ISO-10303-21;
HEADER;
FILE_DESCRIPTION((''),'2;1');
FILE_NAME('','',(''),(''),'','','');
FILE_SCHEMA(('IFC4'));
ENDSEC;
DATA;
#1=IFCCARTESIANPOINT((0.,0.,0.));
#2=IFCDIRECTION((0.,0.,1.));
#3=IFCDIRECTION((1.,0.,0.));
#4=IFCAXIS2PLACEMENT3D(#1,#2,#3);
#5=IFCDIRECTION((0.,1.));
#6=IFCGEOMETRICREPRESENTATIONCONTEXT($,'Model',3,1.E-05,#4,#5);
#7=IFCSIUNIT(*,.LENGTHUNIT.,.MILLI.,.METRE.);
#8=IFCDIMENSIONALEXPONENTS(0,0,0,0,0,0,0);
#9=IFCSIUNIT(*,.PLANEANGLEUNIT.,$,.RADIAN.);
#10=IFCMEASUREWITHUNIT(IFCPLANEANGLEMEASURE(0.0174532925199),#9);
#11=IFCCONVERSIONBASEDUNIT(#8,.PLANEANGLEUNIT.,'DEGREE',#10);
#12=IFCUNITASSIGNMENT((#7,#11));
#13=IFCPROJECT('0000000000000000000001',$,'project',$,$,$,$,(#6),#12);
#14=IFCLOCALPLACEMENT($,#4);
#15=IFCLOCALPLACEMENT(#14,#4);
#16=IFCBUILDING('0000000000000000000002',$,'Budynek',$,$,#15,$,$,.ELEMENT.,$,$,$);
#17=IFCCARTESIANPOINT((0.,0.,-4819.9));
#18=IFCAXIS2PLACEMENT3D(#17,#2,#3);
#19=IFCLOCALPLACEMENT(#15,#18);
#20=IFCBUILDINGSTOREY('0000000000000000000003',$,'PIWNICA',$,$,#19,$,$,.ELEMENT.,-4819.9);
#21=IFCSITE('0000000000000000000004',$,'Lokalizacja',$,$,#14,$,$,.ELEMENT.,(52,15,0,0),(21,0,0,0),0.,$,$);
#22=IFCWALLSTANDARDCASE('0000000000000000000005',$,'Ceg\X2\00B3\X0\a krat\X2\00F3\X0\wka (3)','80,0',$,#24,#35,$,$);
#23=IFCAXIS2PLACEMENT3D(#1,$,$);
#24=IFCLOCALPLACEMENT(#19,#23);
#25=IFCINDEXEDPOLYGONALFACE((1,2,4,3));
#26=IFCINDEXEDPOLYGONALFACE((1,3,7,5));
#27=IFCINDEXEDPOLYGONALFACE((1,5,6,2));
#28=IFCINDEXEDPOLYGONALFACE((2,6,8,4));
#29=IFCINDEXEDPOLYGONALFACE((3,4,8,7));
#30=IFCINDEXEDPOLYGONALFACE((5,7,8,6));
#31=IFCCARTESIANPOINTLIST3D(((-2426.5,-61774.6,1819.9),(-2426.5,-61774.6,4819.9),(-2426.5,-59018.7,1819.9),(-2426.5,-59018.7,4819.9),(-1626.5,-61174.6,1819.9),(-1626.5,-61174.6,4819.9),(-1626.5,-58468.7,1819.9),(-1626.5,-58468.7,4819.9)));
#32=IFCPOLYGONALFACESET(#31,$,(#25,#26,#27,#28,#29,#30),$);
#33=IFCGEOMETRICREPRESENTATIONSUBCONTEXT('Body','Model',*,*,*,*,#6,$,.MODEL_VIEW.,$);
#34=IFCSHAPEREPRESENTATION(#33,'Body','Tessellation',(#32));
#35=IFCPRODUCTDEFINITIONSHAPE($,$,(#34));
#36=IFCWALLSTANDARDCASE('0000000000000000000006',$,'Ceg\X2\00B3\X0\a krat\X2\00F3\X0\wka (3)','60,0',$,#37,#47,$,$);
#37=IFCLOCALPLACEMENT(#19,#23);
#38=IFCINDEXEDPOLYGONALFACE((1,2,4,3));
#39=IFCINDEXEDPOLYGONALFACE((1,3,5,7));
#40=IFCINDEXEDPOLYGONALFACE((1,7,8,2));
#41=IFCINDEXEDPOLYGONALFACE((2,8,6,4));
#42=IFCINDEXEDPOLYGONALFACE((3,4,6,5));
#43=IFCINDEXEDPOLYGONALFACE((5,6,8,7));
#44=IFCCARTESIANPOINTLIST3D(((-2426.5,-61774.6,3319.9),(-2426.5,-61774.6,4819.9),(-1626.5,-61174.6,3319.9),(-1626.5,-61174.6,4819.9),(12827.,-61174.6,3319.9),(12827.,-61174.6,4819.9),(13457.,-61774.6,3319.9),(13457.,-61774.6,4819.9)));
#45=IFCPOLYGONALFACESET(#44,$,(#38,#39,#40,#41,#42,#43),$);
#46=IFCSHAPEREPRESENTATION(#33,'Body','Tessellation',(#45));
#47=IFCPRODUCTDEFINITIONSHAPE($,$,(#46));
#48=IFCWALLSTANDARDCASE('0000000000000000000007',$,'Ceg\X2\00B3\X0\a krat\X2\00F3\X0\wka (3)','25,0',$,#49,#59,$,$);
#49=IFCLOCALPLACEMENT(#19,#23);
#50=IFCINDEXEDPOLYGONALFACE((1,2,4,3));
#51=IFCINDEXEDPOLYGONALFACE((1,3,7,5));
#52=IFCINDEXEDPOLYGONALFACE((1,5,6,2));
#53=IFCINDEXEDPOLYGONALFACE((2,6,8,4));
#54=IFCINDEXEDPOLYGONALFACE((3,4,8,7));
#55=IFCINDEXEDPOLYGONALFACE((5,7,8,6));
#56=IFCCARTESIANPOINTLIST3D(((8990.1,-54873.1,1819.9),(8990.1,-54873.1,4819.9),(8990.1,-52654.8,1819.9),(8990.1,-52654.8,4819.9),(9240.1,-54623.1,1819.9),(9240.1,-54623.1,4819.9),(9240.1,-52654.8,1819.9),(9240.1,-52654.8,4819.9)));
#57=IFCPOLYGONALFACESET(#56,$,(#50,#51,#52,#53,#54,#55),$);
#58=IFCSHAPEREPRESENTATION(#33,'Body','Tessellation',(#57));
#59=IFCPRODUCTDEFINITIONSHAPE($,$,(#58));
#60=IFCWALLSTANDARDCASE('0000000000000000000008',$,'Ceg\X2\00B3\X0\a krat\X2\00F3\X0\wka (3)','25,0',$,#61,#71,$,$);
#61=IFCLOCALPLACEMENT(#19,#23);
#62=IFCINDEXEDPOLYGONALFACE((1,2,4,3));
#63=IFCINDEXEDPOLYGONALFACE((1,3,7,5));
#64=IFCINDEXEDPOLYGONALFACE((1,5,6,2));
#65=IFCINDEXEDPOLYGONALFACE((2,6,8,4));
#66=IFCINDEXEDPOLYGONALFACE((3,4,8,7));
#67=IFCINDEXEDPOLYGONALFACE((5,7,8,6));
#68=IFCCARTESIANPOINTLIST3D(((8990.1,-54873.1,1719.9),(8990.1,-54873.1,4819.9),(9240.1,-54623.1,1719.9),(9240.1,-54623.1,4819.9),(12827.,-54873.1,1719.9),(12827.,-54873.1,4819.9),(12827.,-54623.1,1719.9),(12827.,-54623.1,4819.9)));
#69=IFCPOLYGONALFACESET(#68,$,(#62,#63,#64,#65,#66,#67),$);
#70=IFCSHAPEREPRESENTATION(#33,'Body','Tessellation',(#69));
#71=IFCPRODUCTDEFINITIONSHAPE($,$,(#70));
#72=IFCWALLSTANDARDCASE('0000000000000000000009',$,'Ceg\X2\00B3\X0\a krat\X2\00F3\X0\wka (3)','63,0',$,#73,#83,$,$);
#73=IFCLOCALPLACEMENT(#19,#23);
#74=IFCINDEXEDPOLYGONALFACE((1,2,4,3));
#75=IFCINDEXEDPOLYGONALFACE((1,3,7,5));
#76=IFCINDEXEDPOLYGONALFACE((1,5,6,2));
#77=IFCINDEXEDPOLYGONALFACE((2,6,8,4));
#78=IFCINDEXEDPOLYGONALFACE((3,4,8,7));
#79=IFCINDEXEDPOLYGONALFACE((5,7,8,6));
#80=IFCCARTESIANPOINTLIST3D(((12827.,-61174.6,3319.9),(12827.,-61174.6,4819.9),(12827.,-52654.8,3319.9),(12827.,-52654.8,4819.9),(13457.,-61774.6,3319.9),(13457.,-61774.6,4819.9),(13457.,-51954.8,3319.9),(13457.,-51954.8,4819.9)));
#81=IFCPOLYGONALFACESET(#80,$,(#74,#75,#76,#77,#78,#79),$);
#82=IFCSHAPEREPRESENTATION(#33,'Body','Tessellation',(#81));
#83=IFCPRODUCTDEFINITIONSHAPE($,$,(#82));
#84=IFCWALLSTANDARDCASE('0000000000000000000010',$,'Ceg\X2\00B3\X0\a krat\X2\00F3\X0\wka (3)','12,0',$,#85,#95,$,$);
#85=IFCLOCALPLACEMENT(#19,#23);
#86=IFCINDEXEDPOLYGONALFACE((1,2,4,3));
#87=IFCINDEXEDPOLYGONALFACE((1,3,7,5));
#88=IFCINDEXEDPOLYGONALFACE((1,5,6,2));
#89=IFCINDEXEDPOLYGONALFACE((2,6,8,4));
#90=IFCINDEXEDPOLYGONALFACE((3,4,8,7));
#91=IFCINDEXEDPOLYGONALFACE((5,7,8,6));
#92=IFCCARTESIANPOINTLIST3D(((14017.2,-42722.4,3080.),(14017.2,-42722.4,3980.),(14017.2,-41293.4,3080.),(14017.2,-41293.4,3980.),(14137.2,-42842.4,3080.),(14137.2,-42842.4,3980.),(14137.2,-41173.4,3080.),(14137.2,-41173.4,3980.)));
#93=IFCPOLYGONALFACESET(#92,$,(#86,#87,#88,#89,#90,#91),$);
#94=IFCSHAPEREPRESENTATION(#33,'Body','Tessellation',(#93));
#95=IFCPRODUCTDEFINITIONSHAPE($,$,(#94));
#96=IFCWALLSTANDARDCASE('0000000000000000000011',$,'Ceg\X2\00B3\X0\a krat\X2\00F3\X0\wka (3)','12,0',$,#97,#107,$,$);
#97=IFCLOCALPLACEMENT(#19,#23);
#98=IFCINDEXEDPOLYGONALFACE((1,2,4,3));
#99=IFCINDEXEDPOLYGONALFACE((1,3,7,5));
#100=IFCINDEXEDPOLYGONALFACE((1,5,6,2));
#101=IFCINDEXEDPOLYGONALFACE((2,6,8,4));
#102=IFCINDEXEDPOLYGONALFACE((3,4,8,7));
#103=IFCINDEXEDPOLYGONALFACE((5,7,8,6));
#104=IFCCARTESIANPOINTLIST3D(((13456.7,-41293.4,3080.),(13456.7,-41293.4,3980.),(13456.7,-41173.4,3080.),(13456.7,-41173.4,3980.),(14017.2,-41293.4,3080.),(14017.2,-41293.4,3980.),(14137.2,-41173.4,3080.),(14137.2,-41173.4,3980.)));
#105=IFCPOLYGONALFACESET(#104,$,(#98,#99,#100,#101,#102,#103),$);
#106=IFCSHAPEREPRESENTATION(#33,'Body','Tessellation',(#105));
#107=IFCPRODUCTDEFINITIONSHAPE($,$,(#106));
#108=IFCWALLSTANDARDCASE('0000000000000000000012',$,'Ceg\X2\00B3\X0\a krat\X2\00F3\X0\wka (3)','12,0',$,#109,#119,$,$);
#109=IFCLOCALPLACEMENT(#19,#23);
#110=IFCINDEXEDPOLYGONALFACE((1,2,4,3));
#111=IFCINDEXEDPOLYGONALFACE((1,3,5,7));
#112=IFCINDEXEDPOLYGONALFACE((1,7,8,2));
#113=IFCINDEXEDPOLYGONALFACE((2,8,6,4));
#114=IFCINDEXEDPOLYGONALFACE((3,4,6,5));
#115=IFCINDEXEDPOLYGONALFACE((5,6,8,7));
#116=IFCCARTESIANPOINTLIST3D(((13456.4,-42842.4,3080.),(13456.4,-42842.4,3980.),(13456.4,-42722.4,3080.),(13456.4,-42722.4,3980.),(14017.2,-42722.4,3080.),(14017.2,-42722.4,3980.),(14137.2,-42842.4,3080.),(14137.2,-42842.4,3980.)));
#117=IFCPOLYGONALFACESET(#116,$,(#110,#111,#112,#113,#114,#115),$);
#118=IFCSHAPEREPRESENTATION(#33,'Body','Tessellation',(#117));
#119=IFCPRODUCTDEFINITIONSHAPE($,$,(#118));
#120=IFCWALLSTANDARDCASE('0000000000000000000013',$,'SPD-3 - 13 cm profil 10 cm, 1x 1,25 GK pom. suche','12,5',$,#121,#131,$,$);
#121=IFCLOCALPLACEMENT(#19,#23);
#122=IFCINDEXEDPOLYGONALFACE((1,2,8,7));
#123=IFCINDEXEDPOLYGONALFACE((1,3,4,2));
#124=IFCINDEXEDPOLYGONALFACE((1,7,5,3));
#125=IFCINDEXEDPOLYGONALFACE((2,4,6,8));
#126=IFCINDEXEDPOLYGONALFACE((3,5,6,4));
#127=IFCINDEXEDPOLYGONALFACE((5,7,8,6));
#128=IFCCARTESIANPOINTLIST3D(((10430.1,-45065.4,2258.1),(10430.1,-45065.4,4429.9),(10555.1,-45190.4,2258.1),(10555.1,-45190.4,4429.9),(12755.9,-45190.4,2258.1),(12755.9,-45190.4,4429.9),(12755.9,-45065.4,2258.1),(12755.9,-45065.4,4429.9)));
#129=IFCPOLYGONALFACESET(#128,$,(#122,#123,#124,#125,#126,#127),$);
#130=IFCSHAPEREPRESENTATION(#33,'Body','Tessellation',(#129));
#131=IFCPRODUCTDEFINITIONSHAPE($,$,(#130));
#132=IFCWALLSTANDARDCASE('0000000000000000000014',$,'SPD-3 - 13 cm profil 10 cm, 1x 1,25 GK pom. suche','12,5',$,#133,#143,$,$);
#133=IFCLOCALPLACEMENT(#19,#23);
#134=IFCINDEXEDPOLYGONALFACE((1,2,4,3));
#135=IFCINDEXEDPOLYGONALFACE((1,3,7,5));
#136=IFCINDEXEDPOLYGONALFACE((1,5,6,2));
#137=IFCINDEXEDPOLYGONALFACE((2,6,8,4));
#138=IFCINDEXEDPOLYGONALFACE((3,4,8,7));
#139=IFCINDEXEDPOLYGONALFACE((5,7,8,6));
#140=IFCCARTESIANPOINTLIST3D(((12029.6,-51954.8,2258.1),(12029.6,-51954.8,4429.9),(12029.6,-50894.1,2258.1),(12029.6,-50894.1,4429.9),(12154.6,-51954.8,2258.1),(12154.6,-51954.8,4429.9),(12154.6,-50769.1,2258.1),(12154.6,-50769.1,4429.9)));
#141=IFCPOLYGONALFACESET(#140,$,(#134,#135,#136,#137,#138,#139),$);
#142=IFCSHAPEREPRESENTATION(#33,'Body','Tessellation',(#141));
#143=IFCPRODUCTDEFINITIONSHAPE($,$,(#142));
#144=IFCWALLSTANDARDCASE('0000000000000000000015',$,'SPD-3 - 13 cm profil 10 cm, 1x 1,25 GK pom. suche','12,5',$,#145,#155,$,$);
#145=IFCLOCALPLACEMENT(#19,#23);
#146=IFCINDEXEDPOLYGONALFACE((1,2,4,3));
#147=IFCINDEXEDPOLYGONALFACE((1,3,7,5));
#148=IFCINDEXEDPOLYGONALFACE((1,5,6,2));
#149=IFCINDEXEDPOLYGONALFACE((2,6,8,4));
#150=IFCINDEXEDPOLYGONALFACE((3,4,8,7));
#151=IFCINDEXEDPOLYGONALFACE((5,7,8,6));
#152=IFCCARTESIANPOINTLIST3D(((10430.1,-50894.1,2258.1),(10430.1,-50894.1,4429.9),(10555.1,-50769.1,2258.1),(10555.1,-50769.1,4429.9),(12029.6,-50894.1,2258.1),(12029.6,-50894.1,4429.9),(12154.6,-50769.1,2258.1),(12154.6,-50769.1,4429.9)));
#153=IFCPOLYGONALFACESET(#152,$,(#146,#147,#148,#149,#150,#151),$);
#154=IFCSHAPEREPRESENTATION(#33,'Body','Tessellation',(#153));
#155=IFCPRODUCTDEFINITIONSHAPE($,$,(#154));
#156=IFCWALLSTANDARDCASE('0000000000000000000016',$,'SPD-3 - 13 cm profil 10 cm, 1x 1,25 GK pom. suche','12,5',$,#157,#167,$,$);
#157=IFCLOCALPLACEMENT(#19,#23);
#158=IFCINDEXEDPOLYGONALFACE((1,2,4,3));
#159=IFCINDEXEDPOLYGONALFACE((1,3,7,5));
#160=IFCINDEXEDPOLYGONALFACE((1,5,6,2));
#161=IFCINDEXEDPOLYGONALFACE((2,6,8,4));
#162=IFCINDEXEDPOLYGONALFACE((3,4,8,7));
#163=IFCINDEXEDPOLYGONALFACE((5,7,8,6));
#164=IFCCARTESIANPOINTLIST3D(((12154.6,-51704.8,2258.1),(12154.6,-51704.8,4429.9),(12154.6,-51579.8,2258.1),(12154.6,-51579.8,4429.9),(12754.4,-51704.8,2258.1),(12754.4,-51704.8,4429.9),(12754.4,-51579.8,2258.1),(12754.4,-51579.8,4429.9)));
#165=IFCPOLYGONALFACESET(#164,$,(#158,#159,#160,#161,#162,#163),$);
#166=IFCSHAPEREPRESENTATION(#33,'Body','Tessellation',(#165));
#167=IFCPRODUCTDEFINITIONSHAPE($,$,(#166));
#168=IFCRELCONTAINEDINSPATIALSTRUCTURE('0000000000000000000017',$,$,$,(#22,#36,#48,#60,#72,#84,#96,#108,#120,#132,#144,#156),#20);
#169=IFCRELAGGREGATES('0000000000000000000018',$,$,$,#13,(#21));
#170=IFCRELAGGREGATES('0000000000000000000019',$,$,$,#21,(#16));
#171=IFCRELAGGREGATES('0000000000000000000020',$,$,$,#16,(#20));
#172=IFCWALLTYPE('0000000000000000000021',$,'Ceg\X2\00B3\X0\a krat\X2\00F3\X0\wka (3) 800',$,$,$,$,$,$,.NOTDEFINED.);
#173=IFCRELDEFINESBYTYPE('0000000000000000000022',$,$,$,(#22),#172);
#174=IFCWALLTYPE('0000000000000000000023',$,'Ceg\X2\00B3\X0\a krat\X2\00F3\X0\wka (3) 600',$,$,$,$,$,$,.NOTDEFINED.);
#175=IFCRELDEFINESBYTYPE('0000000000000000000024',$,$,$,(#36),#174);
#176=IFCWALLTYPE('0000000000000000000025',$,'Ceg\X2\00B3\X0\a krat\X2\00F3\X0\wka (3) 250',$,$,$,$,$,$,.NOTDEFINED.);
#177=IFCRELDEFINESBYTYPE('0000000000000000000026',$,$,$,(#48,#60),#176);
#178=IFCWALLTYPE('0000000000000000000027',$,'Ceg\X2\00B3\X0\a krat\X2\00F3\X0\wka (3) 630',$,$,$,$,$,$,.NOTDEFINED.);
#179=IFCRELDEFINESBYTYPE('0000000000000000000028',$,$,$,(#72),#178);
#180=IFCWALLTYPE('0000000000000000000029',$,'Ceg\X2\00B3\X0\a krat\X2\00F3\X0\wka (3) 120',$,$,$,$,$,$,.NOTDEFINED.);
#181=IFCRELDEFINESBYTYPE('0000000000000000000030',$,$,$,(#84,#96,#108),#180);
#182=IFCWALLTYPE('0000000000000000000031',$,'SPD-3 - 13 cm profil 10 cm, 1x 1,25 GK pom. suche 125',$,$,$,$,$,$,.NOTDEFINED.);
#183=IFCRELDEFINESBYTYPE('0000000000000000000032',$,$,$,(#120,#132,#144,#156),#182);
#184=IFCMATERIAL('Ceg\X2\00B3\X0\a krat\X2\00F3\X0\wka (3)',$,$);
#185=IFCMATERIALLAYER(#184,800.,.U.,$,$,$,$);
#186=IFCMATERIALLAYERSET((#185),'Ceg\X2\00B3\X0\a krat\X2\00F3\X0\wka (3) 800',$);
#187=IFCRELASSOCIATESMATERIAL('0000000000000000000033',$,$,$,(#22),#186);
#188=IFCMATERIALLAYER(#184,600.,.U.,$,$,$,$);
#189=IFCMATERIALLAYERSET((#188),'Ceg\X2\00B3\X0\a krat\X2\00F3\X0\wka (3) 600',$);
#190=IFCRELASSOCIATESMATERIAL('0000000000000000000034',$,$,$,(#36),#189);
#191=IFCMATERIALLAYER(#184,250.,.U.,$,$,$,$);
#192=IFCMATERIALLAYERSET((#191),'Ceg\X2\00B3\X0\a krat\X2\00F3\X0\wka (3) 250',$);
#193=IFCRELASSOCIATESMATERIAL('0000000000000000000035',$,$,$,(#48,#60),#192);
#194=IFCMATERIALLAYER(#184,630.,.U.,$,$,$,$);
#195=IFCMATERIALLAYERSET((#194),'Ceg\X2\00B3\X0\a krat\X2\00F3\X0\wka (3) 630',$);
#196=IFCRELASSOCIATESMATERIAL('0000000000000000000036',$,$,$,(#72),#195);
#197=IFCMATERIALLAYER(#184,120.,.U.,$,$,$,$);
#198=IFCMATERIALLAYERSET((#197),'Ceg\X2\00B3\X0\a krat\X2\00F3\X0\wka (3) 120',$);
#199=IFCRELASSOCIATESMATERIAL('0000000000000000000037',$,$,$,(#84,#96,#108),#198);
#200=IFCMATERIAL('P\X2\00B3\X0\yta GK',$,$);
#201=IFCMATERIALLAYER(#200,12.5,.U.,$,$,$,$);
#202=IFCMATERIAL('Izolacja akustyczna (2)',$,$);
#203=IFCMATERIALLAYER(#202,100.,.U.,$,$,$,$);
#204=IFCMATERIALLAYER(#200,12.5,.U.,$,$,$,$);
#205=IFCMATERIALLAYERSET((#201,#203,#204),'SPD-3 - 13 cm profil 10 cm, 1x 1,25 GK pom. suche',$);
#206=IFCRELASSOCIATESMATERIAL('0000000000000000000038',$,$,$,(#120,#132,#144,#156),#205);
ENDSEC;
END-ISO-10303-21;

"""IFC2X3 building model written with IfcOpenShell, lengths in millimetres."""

from ifc_helpers import new_model, entity, si_unit, converted_unit, direction, frame, origin_with_axes, place, context, subcontext, project, spatial, polyline, outline, extrude, material, layer, layer_set, layer_usage, type_object, element, save


model = new_model("IFC2X3")

# Units and contexts
model_context = context("Model", 3, precision=1e-05, world=origin_with_axes(), true_north=direction((0.0, 1.0)))
body_context = subcontext(model_context, "Body", "Model", "MODEL_VIEW")
ifc_project = project(units=[si_unit("LENGTHUNIT", "METRE", prefix="MILLI"), converted_unit("PLANEANGLEUNIT", "DEGREE", entity("IfcPlaneAngleMeasure", 0.0174532925199), si_unit("PLANEANGLEUNIT", "RADIAN"), dimensions=[0, 0, 0, 0, 0, 0, 0])], contexts=[model_context])

# Site, building, storey
site_placement = place(None, origin_with_axes())
site = spatial("IfcSite", under=ifc_project, at=site_placement, Name="Lokalizacja", CompositionType="ELEMENT", RefLatitude=(52, 15, 0, 0), RefLongitude=(21, 0, 0, 0), RefElevation=0.0)
building_placement = place(site_placement, origin_with_axes())
building = spatial("IfcBuilding", under=site, at=building_placement, Name="Budynek", CompositionType="ELEMENT")
storey_placement = place(building_placement, frame((0.0, 0.0, -4819.9), z_axis=(0.0, 0.0, 1.0), x_axis=(1.0, 0.0, 0.0)))
storey = spatial("IfcBuildingStorey", under=building, at=storey_placement, Name="PIWNICA", CompositionType="ELEMENT", Elevation=-4819.9)

# Shared definitions
ifc_material_1 = material(Name="Ceg³a kratówka (3)")

# Walls
ifc_layer_1 = layer(ifc_material_1, 800.0, ventilated="UNKNOWN")
ifc_layer_set_1 = layer_set([ifc_layer_1], Name="Ceg³a kratówka (3) 800")
ifc_layer_usage_1 = layer_usage(ifc_layer_set_1, "AXIS2", "POSITIVE", 0.0)
wall_type_1 = type_object("IfcWallType", Name="Ceg³a kratówka (3) 800", PredefinedType="NOTDEFINED")
wall_1_placement = place(storey_placement, frame((-1626.5, -61174.6, 1819.9), z_axis=(0.0, 0.0, 1.0), x_axis=(0.0, 1.0, 0.0)))
element("IfcWallStandardCase", 1, at=wall_1_placement, inside=storey, type_object=wall_type_1, material=ifc_layer_usage_1, Name="Ceg³a kratówka (3)", Description="80,0", context=body_context, shape_type="SweptSolid", body=[
    extrude(outline(polyline([(0.0, 0.0), (2705.8, 0.0), (2155.8, 800.0), (-600.0, 800.0), (0.0, 0.0)])), origin_with_axes(), (0.0, 0.0, 1.0), 3000.0),
])
ifc_layer_2 = layer(ifc_material_1, 600.0, ventilated="UNKNOWN")
ifc_layer_set_2 = layer_set([ifc_layer_2], Name="Ceg³a kratówka (3) 600")
ifc_layer_usage_2 = layer_usage(ifc_layer_set_2, "AXIS2", "POSITIVE", 0.0)
wall_type_2 = type_object("IfcWallType", Name="Ceg³a kratówka (3) 600", PredefinedType="NOTDEFINED")
wall_2_placement = place(storey_placement, frame((12827.0, -61174.6, 3319.9), z_axis=(0.0, 0.0, 1.0), x_axis=(-1.0, 0.0, 0.0)))
element("IfcWallStandardCase", 2, at=wall_2_placement, inside=storey, type_object=wall_type_2, material=ifc_layer_usage_2, Name="Ceg³a kratówka (3)", Description="60,0", context=body_context, shape_type="SweptSolid", body=[
    extrude(outline(polyline([(0.0, 0.0), (14453.5, 0.0), (15253.5, 600.0), (-630.0, 600.0), (0.0, 0.0)])), origin_with_axes(), (0.0, 0.0, 1.0), 1500.0),
])
ifc_layer_3 = layer(ifc_material_1, 250.0, ventilated="UNKNOWN")
ifc_layer_set_3 = layer_set([ifc_layer_3], Name="Ceg³a kratówka (3) 250")
ifc_layer_usage_3 = layer_usage(ifc_layer_set_3, "AXIS2", "NEGATIVE", 0.0)
wall_type_3 = type_object("IfcWallType", Name="Ceg³a kratówka (3) 250", PredefinedType="NOTDEFINED")
wall_3_placement = place(storey_placement, frame((9240.1, -52654.8, 1819.9), z_axis=(0.0, 0.0, 1.0), x_axis=(0.0, -1.0, 0.0)))
element("IfcWallStandardCase", 3, at=wall_3_placement, inside=storey, type_object=wall_type_3, material=ifc_layer_usage_3, Name="Ceg³a kratówka (3)", Description="25,0", context=body_context, shape_type="SweptSolid", body=[
    extrude(outline(polyline([(0.0, -250.0), (2218.3, -250.0), (1968.3, 0.0), (0.0, 0.0), (0.0, -250.0)])), origin_with_axes(), (0.0, 0.0, 1.0), 3000.0),
])
ifc_layer_usage_4 = layer_usage(ifc_layer_set_3, "AXIS2", "NEGATIVE", 0.0)
wall_4_placement = place(storey_placement, frame((12827.0, -54873.1, 1719.9), z_axis=(0.0, 0.0, 1.0), x_axis=(-1.0, 0.0, 0.0)))
element("IfcWallStandardCase", 4, at=wall_4_placement, inside=storey, type_object=wall_type_3, material=ifc_layer_usage_4, Name="Ceg³a kratówka (3)", Description="25,0", context=body_context, shape_type="SweptSolid", body=[
    extrude(outline(polyline([(0.0, -250.0), (3586.9, -250.0), (3836.9, 0.0), (0.0, 0.0), (0.0, -250.0)])), origin_with_axes(), (0.0, 0.0, 1.0), 3100.0),
])
ifc_layer_4 = layer(ifc_material_1, 630.0, ventilated="UNKNOWN")
ifc_layer_set_4 = layer_set([ifc_layer_4], Name="Ceg³a kratówka (3) 630")
ifc_layer_usage_5 = layer_usage(ifc_layer_set_4, "AXIS2", "POSITIVE", 0.0)
wall_type_4 = type_object("IfcWallType", Name="Ceg³a kratówka (3) 630", PredefinedType="NOTDEFINED")
wall_5_placement = place(storey_placement, frame((12827.0, -52654.8, 3319.9), z_axis=(0.0, 0.0, 1.0), x_axis=(0.0, -1.0, 0.0)))
element("IfcWallStandardCase", 5, at=wall_5_placement, inside=storey, type_object=wall_type_4, material=ifc_layer_usage_5, Name="Ceg³a kratówka (3)", Description="63,0", context=body_context, shape_type="SweptSolid", body=[
    extrude(outline(polyline([(0.0, 0.0), (8519.8, 0.0), (9119.8, 630.0), (-700.0, 630.0), (0.0, 0.0)])), origin_with_axes(), (0.0, 0.0, 1.0), 1500.0),
])
ifc_layer_5 = layer(ifc_material_1, 120.0, ventilated="UNKNOWN")
ifc_layer_set_5 = layer_set([ifc_layer_5], Name="Ceg³a kratówka (3) 120")
ifc_layer_usage_6 = layer_usage(ifc_layer_set_5, "AXIS2", "NEGATIVE", 0.0)
wall_type_5 = type_object("IfcWallType", Name="Ceg³a kratówka (3) 120", PredefinedType="NOTDEFINED")
wall_6_placement = place(storey_placement, frame((14017.2, -42722.4, 3080.0), z_axis=(0.0, 0.0, 1.0), x_axis=(0.0, 1.0, 0.0)))
element("IfcWallStandardCase", 6, at=wall_6_placement, inside=storey, type_object=wall_type_5, material=ifc_layer_usage_6, Name="Ceg³a kratówka (3)", Description="12,0", context=body_context, shape_type="SweptSolid", body=[
    extrude(outline(polyline([(-120.0, -120.0), (1549.0, -120.0), (1429.0, 0.0), (0.0, 0.0), (-120.0, -120.0)])), origin_with_axes(), (0.0, 0.0, 1.0), 900.0),
])
ifc_layer_usage_7 = layer_usage(ifc_layer_set_5, "AXIS2", "NEGATIVE", 0.0)
wall_7_placement = place(storey_placement, frame((14017.2, -41293.4, 3080.0), z_axis=(0.0, 0.0, 1.0), x_axis=(-1.0, 0.0, 0.0)))
element("IfcWallStandardCase", 7, at=wall_7_placement, inside=storey, type_object=wall_type_5, material=ifc_layer_usage_7, Name="Ceg³a kratówka (3)", Description="12,0", context=body_context, shape_type="SweptSolid", body=[
    extrude(outline(polyline([(-120.0, -120.0), (560.4, -120.0), (560.5, 0.0), (0.0, 0.0), (-120.0, -120.0)])), origin_with_axes(), (0.0, 0.0, 1.0), 900.0),
])
ifc_layer_usage_8 = layer_usage(ifc_layer_set_5, "AXIS2", "POSITIVE", 0.0)
wall_8_placement = place(storey_placement, frame((14017.2, -42722.4, 3080.0), z_axis=(0.0, 0.0, 1.0), x_axis=(-1.0, 0.0, 0.0)))
element("IfcWallStandardCase", 8, at=wall_8_placement, inside=storey, type_object=wall_type_5, material=ifc_layer_usage_8, Name="Ceg³a kratówka (3)", Description="12,0", context=body_context, shape_type="SweptSolid", body=[
    extrude(outline(polyline([(0.0, 0.0), (560.8, 0.0), (560.8, 120.0), (-120.0, 120.0), (0.0, 0.0)])), origin_with_axes(), (0.0, 0.0, 1.0), 900.0),
])

# Shared definitions
ifc_material_2 = material(Name="P³yta GK")
ifc_layer_6 = layer(ifc_material_2, 12.5, ventilated="UNKNOWN")
ifc_material_3 = material(Name="Izolacja akustyczna (2)")
ifc_layer_7 = layer(ifc_material_3, 100.0, ventilated="UNKNOWN")
ifc_layer_8 = layer(ifc_material_2, 12.5, ventilated="UNKNOWN")
ifc_layer_set_6 = layer_set([ifc_layer_6, ifc_layer_7, ifc_layer_8], Name="SPD-3 - 13 cm profil 10 cm, 1x 1,25 GK pom. suche")
wall_type_6 = type_object("IfcWallType", Name="SPD-3 - 13 cm profil 10 cm, 1x 1,25 GK pom. suche 125", PredefinedType="NOTDEFINED")

# Walls
ifc_layer_usage_9 = layer_usage(ifc_layer_set_6, "AXIS2", "NEGATIVE", 0.0)
wall_9_placement = place(storey_placement, frame((12755.9, -45190.4, 2258.1), z_axis=(0.0, 0.0, 1.0), x_axis=(-1.0, 0.0, 0.0)))
element("IfcWallStandardCase", 9, at=wall_9_placement, inside=storey, type_object=wall_type_6, material=ifc_layer_usage_9, Name="SPD-3 - 13 cm profil 10 cm, 1x 1,25 GK pom. suche", Description="12,5", context=body_context, shape_type="SweptSolid", body=[
    extrude(outline(polyline([(0.0, -125.0), (2325.7, -125.0), (2200.7, 0.0), (0.0, 0.0), (0.0, -125.0)])), origin_with_axes(), (0.0, 0.0, 1.0), 2171.9),
])
ifc_layer_usage_10 = layer_usage(ifc_layer_set_6, "AXIS2", "NEGATIVE", 0.0)
wall_10_placement = place(storey_placement, frame((12154.6, -50894.1, 2258.1), z_axis=(0.0, 0.0, 1.0), x_axis=(0.0, -1.0, 0.0)))
element("IfcWallStandardCase", 10, at=wall_10_placement, inside=storey, type_object=wall_type_6, material=ifc_layer_usage_10, Name="SPD-3 - 13 cm profil 10 cm, 1x 1,25 GK pom. suche", Description="12,5", context=body_context, shape_type="SweptSolid", body=[
    extrude(outline(polyline([(0.0, -125.0), (1060.7, -125.0), (1060.7, 0.0), (-125.0, 0.0), (0.0, -125.0)])), origin_with_axes(), (0.0, 0.0, 1.0), 2171.9),
])
ifc_layer_usage_11 = layer_usage(ifc_layer_set_6, "AXIS2", "NEGATIVE", 0.0)
wall_11_placement = place(storey_placement, frame((12154.6, -50894.1, 2258.1), z_axis=(0.0, 0.0, 1.0), x_axis=(-1.0, 0.0, 0.0)))
element("IfcWallStandardCase", 11, at=wall_11_placement, inside=storey, type_object=wall_type_6, material=ifc_layer_usage_11, Name="SPD-3 - 13 cm profil 10 cm, 1x 1,25 GK pom. suche", Description="12,5", context=body_context, shape_type="SweptSolid", body=[
    extrude(outline(polyline([(0.0, -125.0), (1599.4, -125.0), (1724.4, 0.0), (125.0, 0.0), (0.0, -125.0)])), origin_with_axes(), (0.0, 0.0, 1.0), 2171.9),
])
ifc_layer_usage_12 = layer_usage(ifc_layer_set_6, "AXIS2", "POSITIVE", 0.0)
wall_12_placement = place(storey_placement, frame((12154.6, -51704.8, 2258.1), z_axis=(0.0, 0.0, 1.0), x_axis=(1.0, 0.0, 0.0)))
element("IfcWallStandardCase", 12, at=wall_12_placement, inside=storey, type_object=wall_type_6, material=ifc_layer_usage_12, Name="SPD-3 - 13 cm profil 10 cm, 1x 1,25 GK pom. suche", Description="12,5", context=body_context, shape_type="SweptSolid", body=[
    extrude(outline(polyline([(0.0, 0.0), (599.9, 0.0), (599.9, 125.0), (0.0, 125.0), (0.0, 0.0)])), origin_with_axes(), (0.0, 0.0, 1.0), 2171.9),
])

save(model, "model.ifc")
